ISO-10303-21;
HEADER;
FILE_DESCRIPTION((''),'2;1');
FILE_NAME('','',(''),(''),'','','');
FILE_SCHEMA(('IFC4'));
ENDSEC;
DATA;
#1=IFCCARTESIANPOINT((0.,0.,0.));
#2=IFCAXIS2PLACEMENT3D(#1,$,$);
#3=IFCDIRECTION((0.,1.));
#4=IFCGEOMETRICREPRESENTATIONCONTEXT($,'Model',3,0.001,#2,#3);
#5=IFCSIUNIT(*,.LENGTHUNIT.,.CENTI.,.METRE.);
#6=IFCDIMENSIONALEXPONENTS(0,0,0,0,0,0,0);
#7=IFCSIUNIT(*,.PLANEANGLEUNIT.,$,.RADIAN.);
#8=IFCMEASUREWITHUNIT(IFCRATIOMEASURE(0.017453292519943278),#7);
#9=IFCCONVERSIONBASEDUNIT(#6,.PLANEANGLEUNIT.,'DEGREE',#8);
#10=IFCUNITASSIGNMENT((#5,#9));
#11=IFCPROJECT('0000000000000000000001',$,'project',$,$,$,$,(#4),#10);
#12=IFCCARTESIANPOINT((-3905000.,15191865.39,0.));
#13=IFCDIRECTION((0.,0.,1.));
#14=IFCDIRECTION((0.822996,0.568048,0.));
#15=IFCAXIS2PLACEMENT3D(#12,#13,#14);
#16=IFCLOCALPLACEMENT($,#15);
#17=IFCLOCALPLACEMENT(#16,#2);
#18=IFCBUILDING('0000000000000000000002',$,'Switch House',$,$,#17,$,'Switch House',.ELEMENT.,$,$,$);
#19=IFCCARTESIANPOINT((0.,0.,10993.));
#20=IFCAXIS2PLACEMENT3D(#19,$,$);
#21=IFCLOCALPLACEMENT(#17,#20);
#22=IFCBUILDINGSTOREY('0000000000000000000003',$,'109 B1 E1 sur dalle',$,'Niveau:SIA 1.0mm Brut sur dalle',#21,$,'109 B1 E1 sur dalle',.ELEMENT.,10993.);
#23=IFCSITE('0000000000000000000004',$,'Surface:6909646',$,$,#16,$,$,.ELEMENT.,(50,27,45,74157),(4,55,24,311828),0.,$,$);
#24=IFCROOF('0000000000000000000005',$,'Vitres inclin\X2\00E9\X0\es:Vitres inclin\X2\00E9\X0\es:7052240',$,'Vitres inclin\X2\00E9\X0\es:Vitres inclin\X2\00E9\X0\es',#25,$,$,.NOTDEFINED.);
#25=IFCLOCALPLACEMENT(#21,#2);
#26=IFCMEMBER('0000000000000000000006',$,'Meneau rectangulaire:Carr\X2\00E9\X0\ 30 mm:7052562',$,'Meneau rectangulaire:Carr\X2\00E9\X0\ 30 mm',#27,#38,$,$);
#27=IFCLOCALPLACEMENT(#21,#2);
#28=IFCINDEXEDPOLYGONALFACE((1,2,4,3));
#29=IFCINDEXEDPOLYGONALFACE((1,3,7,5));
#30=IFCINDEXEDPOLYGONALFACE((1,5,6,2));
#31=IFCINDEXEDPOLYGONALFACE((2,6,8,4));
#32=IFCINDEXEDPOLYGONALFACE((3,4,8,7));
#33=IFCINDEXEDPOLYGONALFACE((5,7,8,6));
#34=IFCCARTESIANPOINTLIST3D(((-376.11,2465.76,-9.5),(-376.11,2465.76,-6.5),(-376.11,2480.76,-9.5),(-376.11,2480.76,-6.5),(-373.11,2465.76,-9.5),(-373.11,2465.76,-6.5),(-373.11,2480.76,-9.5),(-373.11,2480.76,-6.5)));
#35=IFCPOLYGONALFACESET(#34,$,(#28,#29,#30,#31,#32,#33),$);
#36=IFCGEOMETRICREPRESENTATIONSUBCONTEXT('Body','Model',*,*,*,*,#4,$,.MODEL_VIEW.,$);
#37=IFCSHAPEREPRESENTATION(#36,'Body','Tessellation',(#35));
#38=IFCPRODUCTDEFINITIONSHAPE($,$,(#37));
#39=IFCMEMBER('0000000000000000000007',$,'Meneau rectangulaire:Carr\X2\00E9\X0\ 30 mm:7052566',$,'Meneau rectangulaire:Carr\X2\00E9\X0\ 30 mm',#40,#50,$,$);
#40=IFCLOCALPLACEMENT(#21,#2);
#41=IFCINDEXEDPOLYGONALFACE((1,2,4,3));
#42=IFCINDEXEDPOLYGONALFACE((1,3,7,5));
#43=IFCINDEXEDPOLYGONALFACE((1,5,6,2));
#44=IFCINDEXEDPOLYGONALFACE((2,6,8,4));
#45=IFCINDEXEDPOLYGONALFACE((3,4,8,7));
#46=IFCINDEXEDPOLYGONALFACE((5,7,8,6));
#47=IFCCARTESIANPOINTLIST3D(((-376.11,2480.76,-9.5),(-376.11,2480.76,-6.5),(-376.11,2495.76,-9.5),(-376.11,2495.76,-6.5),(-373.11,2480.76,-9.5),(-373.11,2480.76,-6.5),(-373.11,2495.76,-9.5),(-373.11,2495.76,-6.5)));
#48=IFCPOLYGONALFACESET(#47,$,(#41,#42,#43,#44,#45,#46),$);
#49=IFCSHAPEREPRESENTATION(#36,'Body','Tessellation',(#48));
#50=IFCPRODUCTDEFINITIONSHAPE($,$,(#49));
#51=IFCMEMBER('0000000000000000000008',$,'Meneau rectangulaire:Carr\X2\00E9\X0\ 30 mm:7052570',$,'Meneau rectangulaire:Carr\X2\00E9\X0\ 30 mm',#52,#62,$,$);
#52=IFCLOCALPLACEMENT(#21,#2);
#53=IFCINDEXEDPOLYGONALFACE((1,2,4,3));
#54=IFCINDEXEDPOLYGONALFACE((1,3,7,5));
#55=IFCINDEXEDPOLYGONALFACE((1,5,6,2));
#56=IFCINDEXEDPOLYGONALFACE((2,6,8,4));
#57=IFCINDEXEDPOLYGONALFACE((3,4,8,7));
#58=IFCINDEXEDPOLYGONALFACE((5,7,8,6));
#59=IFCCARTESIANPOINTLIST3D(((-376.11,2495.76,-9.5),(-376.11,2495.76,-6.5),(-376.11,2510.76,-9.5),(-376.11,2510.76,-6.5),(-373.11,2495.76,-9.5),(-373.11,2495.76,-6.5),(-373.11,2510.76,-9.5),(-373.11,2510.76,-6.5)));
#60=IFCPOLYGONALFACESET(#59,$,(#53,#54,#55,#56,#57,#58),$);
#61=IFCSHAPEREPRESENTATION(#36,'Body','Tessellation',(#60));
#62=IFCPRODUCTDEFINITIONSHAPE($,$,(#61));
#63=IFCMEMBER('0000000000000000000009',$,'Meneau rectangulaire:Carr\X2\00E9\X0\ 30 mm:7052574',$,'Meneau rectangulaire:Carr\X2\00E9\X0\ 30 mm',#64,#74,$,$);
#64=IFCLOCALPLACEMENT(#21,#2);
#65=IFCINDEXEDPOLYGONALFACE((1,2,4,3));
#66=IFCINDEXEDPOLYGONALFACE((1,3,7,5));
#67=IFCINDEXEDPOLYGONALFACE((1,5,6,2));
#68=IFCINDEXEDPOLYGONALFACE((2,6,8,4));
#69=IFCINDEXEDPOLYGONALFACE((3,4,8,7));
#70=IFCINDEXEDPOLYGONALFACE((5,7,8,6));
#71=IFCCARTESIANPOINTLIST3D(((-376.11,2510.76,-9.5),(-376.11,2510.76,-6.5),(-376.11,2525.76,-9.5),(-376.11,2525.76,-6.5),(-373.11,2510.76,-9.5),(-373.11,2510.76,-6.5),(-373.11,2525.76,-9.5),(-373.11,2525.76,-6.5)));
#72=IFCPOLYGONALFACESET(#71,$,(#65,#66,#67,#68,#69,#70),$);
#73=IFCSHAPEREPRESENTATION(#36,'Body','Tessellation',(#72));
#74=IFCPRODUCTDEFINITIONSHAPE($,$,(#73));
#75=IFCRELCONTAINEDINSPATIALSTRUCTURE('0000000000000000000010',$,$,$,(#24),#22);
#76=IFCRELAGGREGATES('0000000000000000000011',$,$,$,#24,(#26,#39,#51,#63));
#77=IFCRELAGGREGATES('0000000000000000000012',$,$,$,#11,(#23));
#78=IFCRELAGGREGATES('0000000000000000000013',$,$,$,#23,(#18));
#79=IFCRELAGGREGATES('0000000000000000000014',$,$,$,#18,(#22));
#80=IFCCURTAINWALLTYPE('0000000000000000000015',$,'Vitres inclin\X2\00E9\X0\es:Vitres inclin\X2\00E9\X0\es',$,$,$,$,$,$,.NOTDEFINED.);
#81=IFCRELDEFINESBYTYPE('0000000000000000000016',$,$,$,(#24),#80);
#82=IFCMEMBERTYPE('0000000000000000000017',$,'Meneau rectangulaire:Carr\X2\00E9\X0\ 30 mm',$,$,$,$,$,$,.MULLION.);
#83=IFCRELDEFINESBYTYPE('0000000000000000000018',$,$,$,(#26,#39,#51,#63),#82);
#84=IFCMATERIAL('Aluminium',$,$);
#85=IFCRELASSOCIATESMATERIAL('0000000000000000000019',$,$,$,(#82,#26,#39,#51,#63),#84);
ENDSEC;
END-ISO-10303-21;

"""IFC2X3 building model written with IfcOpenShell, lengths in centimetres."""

from ifc_helpers import new_model, entity, si_unit, converted_unit, direction, frame, origin, origin_2d_with_axis, place, context, subcontext, project, spatial, rectangle, extrude, source, transform, mapped, material, type_object, type_shapes, element, aggregate, save


model = new_model("IFC2X3")

# Units and contexts
model_context = context("Model", 3, precision=0.001, world=origin(), true_north=direction((0.0, 1.0)))
body_context = subcontext(model_context, "Body", "Model", "MODEL_VIEW")
ifc_project = project(units=[si_unit("LENGTHUNIT", "METRE", prefix="CENTI"), converted_unit("PLANEANGLEUNIT", "DEGREE", entity("IfcRatioMeasure", 0.017453292519943278), si_unit("PLANEANGLEUNIT", "RADIAN"), dimensions=[0, 0, 0, 0, 0, 0, 0])], contexts=[model_context])

# Site, building, storey
site_placement = place(None, frame((-3905000.0, 15191865.39, 0.0), z_axis=(0.0, 0.0, 1.0), x_axis=(0.822996, 0.568048, 0.0)))
site = spatial("IfcSite", under=ifc_project, at=site_placement, Name="Surface:6909646", CompositionType="ELEMENT", RefLatitude=(50, 27, 45, 74157), RefLongitude=(4, 55, 24, 311828), RefElevation=0.0)
building_placement = place(site_placement, origin())
building = spatial("IfcBuilding", under=site, at=building_placement, Name="Switch House", LongName="Switch House", CompositionType="ELEMENT")
storey_placement = place(building_placement, frame((0.0, 0.0, 10993.0)))
storey = spatial("IfcBuildingStorey", under=building, at=storey_placement, Name="109 B1 E1 sur dalle", ObjectType="Niveau:SIA 1.0mm Brut sur dalle", LongName="109 B1 E1 sur dalle", CompositionType="ELEMENT", Elevation=10993.0)

# Roof, members
curtain_wall_type = type_object("IfcCurtainWallType", Name="Vitres inclinées:Vitres inclinées", PredefinedType="NOTDEFINED")
roof_placement = place(storey_placement, frame((0.0, 0.0, -10993.0)))
roof = element("IfcRoof", 1, at=roof_placement, inside=storey, type_object=curtain_wall_type, Name="Vitres inclinées:Vitres inclinées:7052240", ObjectType="Vitres inclinées:Vitres inclinées", ShapeType="NOTDEFINED")
ifc_material = material(Name="Aluminium")
member_type_1 = type_object("IfcMemberType", Name="Meneau rectangulaire:Carré 30 mm", PredefinedType="MULLION", material=ifc_material)
shared_shape_1 = source(origin(), body_context, "Body", "SweptSolid", [
    extrude(rectangle(XDim=3.0, YDim=3.0, at=origin_2d_with_axis()), frame((0.0, 0.0, -15.0), z_axis=(0.0, 0.0, 1.0), x_axis=(0.0, -1.0, 0.0)), (0.0, 0.0, 1.0), 15.0),
])
type_shapes(member_type_1, [shared_shape_1])
member_1_placement = place(roof_placement, frame((-374.61, 2480.76, 10985.0), z_axis=(0.0, 1.0, 0.0), x_axis=(1.0, 0.0, 0.0)))
member_1 = element("IfcMember", 2, at=member_1_placement, type_object=member_type_1, material=ifc_material, Name="Meneau rectangulaire:Carré 30 mm:7052562", ObjectType="Meneau rectangulaire:Carré 30 mm", context=body_context, shape_type="MappedRepresentation", body=[
    mapped(shared_shape_1, transform((0.0, 0.0, 0.0), scale=1.0)),
])
member_2_placement = place(roof_placement, frame((-374.61, 2495.76, 10985.0), z_axis=(0.0, 1.0, 0.0), x_axis=(1.0, 0.0, 0.0)))
member_2 = element("IfcMember", 3, at=member_2_placement, type_object=member_type_1, material=ifc_material, Name="Meneau rectangulaire:Carré 30 mm:7052566", ObjectType="Meneau rectangulaire:Carré 30 mm", context=body_context, shape_type="MappedRepresentation", body=[
    mapped(shared_shape_1, transform((0.0, 0.0, 0.0), scale=1.0)),
])
member_3_placement = place(roof_placement, frame((-374.61, 2510.76, 10985.0), z_axis=(0.0, 1.0, 0.0), x_axis=(1.0, 0.0, 0.0)))
member_3 = element("IfcMember", 4, at=member_3_placement, type_object=member_type_1, material=ifc_material, Name="Meneau rectangulaire:Carré 30 mm:7052570", ObjectType="Meneau rectangulaire:Carré 30 mm", context=body_context, shape_type="MappedRepresentation", body=[
    mapped(shared_shape_1, transform((0.0, 0.0, 0.0), scale=1.0)),
])
member_4_placement = place(roof_placement, frame((-374.61, 2525.76, 10985.0), z_axis=(0.0, 1.0, 0.0), x_axis=(1.0, 0.0, 0.0)))
member_4 = element("IfcMember", 5, at=member_4_placement, type_object=member_type_1, material=ifc_material, Name="Meneau rectangulaire:Carré 30 mm:7052574", ObjectType="Meneau rectangulaire:Carré 30 mm", context=body_context, shape_type="MappedRepresentation", body=[
    mapped(shared_shape_1, transform((0.0, 0.0, 0.0), scale=1.0)),
])
aggregate(roof, [member_1, member_2, member_3, member_4])

save(model, "model.ifc")
